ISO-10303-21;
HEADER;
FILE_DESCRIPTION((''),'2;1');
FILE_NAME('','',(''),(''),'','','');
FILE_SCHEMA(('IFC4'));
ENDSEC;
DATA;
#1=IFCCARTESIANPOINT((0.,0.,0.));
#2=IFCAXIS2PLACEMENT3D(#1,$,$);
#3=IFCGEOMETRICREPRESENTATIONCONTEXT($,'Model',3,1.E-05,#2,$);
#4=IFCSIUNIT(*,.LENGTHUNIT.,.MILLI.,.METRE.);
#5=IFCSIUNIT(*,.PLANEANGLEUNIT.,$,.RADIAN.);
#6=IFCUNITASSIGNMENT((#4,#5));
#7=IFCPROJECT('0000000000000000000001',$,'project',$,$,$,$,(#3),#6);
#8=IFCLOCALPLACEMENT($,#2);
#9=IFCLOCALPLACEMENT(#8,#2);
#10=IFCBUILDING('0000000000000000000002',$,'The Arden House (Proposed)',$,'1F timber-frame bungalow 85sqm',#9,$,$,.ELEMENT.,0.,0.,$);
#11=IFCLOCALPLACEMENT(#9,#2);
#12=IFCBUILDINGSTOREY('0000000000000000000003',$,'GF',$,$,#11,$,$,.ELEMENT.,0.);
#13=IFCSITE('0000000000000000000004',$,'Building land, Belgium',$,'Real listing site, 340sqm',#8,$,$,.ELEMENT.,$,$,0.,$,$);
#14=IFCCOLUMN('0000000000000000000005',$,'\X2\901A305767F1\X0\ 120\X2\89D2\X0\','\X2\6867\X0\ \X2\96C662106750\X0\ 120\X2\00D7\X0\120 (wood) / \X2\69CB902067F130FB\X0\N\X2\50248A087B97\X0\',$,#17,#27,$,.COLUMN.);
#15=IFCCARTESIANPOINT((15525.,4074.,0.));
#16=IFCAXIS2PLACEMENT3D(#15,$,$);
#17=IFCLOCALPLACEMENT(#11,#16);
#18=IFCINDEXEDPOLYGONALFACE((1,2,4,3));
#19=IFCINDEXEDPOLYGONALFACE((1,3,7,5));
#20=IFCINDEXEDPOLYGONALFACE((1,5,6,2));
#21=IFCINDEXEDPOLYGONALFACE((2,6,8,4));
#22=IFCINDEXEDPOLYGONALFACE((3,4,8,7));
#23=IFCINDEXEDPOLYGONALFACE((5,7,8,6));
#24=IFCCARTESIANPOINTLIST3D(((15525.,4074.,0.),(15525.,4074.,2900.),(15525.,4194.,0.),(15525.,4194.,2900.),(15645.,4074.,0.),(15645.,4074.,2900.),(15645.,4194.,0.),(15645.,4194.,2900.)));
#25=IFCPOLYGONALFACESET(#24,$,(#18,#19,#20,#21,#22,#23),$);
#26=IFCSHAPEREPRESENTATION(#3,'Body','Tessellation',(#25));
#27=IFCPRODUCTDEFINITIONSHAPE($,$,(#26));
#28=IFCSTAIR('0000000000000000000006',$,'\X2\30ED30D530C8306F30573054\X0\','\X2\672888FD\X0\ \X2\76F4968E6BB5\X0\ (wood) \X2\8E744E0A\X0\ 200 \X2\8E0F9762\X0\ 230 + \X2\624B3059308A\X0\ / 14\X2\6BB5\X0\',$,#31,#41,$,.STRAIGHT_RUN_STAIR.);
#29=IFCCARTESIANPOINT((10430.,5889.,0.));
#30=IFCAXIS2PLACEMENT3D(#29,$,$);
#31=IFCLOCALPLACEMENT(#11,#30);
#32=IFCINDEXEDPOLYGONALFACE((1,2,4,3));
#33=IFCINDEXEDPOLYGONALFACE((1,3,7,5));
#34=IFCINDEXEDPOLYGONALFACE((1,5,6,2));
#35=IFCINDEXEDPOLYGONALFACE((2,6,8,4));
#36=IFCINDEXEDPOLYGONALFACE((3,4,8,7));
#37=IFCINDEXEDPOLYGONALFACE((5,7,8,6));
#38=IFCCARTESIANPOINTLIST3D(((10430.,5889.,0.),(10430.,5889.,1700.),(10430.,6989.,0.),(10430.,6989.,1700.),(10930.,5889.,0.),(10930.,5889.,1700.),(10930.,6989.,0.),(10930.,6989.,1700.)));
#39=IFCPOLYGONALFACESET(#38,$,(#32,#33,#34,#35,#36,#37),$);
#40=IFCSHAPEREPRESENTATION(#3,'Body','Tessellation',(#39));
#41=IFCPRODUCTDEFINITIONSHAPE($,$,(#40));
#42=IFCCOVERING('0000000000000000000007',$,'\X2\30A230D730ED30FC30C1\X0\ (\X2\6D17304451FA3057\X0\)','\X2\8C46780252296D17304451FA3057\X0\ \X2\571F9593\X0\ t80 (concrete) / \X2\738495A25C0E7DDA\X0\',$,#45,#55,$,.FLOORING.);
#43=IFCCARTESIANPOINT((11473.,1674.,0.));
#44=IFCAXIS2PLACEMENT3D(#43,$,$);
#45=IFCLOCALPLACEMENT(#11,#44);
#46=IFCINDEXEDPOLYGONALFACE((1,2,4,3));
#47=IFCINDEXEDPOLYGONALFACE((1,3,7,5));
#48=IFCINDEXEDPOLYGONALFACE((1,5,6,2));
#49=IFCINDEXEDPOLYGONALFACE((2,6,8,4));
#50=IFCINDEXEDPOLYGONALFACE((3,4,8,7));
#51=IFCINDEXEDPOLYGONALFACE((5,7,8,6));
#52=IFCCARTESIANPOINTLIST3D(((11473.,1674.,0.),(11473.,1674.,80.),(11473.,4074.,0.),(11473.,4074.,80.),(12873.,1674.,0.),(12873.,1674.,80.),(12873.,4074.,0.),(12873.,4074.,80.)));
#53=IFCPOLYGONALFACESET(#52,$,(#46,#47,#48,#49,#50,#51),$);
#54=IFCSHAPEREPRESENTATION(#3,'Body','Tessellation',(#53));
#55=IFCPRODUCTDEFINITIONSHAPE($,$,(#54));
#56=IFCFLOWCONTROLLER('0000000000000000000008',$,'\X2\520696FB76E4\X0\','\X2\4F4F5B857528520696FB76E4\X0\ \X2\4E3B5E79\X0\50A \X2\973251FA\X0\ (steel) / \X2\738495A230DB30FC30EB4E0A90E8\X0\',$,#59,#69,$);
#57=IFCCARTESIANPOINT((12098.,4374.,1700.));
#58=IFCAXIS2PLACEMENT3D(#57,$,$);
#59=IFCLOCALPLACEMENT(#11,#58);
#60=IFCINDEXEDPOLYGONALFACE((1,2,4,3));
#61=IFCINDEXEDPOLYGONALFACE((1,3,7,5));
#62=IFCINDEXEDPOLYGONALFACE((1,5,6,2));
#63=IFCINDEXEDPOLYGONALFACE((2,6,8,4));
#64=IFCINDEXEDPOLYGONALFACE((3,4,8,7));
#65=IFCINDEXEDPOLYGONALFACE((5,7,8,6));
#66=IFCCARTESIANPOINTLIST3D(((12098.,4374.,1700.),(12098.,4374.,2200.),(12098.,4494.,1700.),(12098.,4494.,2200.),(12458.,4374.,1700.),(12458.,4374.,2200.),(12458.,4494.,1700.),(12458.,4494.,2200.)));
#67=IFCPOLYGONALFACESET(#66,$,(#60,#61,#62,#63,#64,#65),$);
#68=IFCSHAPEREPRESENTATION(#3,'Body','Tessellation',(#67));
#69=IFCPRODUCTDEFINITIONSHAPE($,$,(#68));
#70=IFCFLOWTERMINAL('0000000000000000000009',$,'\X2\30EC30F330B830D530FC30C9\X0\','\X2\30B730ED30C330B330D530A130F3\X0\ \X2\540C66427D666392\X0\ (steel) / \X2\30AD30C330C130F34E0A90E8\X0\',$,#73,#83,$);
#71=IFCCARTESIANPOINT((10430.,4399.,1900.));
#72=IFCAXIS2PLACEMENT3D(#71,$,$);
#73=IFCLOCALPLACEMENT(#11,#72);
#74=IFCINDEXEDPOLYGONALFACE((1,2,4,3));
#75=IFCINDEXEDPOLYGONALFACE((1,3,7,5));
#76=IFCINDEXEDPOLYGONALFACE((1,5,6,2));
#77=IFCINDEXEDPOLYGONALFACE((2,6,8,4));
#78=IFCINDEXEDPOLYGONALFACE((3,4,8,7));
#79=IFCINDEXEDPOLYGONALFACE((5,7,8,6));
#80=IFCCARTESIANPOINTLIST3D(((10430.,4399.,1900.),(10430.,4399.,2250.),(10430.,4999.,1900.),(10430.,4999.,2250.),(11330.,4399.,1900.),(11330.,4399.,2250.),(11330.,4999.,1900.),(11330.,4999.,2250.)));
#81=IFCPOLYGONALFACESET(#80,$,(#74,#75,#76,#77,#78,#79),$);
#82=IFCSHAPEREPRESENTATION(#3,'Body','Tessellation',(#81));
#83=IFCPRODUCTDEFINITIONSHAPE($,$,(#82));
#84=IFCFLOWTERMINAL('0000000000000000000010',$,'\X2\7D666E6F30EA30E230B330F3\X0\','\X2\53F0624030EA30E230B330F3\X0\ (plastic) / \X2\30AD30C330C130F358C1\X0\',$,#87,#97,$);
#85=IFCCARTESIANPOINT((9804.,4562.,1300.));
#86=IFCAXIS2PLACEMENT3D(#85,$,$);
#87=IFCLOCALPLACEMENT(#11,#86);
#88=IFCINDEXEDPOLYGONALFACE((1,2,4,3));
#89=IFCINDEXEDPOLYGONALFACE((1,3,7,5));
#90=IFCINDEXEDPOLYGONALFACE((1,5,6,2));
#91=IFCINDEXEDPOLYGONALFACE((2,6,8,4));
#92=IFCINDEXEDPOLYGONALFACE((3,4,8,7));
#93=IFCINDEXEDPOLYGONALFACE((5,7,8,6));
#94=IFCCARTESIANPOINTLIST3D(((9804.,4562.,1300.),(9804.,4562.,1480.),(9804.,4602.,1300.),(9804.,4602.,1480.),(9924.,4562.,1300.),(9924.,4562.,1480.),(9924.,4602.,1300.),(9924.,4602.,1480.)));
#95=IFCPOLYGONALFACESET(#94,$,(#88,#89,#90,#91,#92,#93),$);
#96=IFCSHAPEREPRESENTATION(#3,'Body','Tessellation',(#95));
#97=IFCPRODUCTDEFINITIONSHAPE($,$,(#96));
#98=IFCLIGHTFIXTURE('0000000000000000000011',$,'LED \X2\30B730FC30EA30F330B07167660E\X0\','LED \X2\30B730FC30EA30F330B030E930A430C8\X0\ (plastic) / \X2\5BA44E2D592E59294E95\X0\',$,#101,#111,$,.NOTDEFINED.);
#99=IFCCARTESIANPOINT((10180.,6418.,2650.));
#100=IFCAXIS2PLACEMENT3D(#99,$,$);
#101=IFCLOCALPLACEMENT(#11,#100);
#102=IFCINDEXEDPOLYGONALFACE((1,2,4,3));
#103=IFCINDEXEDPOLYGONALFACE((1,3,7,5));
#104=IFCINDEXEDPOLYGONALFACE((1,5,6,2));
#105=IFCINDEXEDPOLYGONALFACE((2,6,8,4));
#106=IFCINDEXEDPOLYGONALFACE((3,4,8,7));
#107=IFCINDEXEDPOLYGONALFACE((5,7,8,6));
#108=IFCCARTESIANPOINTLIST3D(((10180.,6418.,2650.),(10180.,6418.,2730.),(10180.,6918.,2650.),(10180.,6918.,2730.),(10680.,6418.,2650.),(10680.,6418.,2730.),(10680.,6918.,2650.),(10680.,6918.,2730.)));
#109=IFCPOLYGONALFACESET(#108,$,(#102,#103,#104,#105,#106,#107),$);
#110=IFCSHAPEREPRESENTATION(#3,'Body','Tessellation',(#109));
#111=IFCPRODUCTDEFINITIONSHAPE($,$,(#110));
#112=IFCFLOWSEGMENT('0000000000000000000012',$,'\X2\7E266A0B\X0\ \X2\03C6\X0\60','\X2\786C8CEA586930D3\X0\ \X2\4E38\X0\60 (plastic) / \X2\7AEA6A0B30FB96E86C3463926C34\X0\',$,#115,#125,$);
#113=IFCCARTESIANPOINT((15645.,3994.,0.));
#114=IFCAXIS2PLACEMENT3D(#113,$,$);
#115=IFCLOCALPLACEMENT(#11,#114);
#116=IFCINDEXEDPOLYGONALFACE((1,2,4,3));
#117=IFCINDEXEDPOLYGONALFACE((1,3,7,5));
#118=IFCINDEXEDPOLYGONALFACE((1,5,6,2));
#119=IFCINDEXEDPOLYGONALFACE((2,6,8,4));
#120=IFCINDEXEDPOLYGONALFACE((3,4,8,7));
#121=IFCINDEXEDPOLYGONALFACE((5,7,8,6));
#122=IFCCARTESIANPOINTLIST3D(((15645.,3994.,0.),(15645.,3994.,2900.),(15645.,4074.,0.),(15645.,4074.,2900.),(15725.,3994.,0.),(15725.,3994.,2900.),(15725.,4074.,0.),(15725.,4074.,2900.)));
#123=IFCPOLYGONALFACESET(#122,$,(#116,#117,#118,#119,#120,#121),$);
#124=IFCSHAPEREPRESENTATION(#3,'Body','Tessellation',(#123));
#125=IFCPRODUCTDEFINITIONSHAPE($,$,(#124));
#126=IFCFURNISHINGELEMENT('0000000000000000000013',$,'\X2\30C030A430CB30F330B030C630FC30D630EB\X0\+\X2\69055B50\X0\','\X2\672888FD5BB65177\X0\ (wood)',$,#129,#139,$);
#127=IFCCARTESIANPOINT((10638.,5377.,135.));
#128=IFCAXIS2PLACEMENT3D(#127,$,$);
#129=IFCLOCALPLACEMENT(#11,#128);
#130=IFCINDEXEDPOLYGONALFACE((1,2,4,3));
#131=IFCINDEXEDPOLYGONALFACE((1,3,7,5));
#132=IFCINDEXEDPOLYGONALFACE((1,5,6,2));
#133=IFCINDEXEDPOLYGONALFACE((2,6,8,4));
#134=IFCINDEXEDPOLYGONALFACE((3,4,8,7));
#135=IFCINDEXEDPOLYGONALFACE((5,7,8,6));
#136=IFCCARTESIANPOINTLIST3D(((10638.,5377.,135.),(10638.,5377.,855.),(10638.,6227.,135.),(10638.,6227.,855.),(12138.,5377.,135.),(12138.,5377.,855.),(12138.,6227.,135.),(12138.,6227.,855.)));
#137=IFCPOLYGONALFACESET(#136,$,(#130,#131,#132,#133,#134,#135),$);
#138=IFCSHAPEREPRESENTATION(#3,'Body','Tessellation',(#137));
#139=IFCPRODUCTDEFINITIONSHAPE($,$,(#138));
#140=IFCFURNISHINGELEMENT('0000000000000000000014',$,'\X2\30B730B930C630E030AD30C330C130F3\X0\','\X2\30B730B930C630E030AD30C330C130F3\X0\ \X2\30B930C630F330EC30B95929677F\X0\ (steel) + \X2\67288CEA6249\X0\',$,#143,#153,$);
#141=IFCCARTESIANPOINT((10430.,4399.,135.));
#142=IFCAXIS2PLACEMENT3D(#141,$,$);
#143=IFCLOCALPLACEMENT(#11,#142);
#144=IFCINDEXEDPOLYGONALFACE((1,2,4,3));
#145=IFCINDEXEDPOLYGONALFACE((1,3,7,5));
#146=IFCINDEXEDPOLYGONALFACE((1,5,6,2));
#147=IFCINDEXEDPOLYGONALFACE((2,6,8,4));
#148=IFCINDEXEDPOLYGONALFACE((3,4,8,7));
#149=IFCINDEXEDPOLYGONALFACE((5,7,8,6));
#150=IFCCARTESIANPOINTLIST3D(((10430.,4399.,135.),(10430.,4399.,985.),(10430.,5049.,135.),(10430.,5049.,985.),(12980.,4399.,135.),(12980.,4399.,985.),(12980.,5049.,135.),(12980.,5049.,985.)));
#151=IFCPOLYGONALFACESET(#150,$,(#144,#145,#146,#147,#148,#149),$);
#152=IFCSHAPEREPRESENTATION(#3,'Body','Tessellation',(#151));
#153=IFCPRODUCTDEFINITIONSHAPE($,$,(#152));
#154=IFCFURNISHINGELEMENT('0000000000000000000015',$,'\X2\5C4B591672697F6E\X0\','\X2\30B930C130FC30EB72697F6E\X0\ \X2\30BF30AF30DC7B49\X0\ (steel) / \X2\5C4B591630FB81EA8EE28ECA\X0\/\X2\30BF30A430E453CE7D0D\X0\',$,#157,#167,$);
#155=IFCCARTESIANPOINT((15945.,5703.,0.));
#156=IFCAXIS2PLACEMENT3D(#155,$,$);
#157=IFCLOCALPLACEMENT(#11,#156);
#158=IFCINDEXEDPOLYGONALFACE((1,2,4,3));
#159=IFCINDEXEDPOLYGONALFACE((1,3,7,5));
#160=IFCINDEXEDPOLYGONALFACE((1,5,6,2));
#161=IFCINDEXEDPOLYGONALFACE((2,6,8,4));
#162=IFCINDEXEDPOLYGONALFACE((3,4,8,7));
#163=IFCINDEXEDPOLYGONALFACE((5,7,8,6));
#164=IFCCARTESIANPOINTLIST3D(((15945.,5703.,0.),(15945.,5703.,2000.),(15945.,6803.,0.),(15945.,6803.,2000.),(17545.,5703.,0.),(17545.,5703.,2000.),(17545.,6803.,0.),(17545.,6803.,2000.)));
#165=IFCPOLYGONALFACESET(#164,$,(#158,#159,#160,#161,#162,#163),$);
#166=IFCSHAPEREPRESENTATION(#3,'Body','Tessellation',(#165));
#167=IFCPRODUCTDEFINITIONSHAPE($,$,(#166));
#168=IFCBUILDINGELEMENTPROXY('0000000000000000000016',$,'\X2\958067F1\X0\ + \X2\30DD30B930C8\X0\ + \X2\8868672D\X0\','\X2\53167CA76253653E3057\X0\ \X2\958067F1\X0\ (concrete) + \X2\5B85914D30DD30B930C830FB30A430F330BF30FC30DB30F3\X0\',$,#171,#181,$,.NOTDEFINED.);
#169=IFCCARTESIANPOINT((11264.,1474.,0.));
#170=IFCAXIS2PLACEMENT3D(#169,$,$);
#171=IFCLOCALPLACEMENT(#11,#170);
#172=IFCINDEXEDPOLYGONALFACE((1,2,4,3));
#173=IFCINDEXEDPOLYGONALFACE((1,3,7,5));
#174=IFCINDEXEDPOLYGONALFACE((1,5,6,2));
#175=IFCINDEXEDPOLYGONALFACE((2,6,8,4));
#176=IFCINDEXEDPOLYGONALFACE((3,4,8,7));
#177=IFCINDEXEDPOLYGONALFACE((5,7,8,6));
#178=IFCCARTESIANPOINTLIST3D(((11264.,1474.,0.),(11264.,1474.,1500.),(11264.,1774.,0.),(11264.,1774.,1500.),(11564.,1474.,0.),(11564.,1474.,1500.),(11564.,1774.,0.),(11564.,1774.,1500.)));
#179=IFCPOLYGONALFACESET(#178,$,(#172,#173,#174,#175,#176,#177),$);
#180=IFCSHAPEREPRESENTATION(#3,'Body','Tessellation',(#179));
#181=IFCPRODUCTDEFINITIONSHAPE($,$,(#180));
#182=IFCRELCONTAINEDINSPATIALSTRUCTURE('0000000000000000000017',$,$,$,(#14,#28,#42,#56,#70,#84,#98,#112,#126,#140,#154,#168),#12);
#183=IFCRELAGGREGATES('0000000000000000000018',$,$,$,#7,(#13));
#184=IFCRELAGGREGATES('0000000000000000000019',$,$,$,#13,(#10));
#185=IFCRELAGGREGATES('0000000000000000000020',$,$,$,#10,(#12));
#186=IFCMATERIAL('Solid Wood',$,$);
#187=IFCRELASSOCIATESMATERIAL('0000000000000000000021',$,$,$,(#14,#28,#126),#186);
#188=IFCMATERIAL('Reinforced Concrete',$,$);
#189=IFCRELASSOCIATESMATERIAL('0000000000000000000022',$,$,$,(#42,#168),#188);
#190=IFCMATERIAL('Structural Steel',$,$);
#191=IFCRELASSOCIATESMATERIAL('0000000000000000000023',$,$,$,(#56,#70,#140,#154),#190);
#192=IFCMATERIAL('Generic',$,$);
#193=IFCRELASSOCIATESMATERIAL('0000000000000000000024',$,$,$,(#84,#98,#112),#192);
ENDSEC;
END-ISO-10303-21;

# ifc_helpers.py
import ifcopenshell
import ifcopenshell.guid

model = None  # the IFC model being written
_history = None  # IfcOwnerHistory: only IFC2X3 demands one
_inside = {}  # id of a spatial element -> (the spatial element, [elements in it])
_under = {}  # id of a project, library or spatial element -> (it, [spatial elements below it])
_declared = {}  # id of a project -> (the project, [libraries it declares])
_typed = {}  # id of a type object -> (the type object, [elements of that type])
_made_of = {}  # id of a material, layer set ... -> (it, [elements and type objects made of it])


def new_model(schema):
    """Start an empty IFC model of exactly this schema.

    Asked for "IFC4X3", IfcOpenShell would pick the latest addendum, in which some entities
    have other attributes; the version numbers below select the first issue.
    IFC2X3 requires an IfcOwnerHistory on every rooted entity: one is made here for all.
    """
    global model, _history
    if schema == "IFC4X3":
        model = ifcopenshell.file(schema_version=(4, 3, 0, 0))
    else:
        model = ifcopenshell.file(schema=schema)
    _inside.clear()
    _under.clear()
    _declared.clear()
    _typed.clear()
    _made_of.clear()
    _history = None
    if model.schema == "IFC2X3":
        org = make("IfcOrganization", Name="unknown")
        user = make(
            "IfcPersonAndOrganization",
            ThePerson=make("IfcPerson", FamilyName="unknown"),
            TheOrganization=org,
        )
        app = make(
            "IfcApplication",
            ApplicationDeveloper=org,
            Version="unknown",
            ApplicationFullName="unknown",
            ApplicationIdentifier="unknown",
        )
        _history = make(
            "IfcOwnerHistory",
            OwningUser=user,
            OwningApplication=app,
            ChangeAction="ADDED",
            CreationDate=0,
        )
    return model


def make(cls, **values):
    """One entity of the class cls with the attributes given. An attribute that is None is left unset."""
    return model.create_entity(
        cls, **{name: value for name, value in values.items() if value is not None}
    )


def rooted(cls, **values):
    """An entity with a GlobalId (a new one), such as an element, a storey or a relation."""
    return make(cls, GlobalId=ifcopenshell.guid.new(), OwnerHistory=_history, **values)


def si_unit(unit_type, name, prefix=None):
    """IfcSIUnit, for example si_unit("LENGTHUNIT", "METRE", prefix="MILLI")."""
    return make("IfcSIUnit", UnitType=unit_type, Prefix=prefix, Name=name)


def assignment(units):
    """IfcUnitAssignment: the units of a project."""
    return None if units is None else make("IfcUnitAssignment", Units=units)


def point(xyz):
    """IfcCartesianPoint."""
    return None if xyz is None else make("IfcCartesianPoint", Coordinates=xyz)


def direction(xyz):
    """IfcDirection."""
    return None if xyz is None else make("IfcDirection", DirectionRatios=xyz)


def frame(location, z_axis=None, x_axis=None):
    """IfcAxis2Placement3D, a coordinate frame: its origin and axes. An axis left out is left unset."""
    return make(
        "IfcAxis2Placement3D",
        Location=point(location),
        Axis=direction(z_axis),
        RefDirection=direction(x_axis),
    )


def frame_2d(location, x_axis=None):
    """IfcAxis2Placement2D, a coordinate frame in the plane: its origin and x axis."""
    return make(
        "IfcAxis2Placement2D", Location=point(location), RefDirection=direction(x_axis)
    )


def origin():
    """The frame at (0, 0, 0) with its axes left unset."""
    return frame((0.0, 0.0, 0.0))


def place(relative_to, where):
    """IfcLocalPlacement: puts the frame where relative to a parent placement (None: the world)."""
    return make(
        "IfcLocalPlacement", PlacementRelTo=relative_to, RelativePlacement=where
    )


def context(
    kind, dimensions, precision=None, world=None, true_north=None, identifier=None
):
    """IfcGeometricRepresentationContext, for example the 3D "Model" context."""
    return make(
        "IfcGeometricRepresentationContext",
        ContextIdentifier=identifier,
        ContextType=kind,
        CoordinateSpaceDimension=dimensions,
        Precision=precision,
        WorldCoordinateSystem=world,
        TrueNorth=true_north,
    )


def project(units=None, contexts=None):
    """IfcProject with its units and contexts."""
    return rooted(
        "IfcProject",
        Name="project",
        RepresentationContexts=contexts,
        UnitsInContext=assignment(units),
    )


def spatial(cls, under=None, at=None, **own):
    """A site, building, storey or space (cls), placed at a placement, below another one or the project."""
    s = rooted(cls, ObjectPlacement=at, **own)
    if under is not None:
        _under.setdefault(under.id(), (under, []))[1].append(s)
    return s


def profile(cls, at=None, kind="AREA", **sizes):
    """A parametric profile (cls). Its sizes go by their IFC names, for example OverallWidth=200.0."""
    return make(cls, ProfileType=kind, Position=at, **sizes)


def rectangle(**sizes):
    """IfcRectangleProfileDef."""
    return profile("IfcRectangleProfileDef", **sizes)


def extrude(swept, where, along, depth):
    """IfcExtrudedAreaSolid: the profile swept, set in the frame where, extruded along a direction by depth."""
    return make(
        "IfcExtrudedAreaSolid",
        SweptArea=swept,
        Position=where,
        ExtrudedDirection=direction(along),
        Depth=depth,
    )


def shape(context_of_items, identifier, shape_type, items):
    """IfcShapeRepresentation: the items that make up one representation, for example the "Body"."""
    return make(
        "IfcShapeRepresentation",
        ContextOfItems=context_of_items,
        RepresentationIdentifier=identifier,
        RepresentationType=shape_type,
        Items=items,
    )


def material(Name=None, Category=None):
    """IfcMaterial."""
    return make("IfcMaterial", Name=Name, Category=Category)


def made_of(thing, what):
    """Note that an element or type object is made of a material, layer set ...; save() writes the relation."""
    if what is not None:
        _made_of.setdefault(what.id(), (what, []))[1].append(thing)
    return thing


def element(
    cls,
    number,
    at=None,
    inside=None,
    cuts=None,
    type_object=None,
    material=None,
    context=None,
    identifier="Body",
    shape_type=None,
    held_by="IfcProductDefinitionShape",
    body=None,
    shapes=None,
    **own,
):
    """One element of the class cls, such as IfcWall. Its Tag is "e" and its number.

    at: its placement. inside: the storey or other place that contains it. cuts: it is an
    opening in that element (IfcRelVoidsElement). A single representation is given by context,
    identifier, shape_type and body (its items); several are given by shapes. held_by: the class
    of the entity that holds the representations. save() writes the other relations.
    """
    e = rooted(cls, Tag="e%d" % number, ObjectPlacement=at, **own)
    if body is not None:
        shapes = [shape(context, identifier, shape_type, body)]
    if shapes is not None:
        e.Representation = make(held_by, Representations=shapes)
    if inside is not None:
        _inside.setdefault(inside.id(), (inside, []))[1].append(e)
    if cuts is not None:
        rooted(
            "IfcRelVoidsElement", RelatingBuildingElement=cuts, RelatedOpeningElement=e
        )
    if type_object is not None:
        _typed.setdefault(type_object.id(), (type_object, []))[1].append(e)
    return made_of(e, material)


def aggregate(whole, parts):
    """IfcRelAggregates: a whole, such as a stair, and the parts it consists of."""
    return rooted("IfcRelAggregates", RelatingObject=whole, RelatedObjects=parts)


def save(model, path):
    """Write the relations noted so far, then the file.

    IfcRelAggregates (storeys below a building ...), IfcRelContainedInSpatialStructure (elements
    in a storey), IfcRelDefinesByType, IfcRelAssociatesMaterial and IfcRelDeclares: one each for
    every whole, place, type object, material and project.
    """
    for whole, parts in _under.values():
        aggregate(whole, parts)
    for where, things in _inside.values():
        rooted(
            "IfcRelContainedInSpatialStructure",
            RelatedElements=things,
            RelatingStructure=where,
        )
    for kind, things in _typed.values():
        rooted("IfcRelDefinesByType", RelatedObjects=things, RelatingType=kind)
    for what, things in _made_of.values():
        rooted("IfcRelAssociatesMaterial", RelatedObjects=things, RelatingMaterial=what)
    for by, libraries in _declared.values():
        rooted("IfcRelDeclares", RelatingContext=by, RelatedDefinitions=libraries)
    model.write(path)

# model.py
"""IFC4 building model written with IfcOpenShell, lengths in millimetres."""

from ifc_helpers import new_model, si_unit, frame, frame_2d, origin, place, context, project, spatial, rectangle, extrude, material, element, save


model = new_model("IFC4")

# Units and contexts
model_context = context("Model", 3, precision=1e-05, world=origin())
ifc_project = project(units=[si_unit("LENGTHUNIT", "METRE", prefix="MILLI"), si_unit("PLANEANGLEUNIT", "RADIAN")], contexts=[model_context])

# Site, building, storey
site_placement = place(None, origin())
site = spatial("IfcSite", under=ifc_project, at=site_placement, Name="Building land, Belgium", ObjectType="Real listing site, 340sqm", CompositionType="ELEMENT", RefElevation=0.0)
building_placement = place(site_placement, origin())
building = spatial("IfcBuilding", under=site, at=building_placement, Name="The Arden House (Proposed)", ObjectType="1F timber-frame bungalow 85sqm", CompositionType="ELEMENT", ElevationOfRefHeight=0.0, ElevationOfTerrain=0.0)
storey_placement = place(building_placement, origin())
storey = spatial("IfcBuildingStorey", under=building, at=storey_placement, Name="GF", CompositionType="ELEMENT", Elevation=0.0)

# Column
ifc_material_1 = material(Name="Solid Wood")
column_1_placement = place(storey_placement, frame((15525.0, 4074.0, 0.0)))
element("IfcColumn", 1, at=column_1_placement, inside=storey, material=ifc_material_1, Name="通し柱 120角", Description="桧 集成材 120×120 (wood) / 構造柱・N値計算", PredefinedType="COLUMN", context=model_context, shape_type="SweptSolid", body=[
    extrude(rectangle(XDim=120.0, YDim=120.0, at=frame_2d((60.0, 60.0))), frame((15525.0, 4074.0, 0.0)), (0.0, 0.0, 1.0), 2900.0),
])

# Stair
stair_placement = place(storey_placement, frame((10430.0, 5889.0, 0.0)))
element("IfcStair", 2, at=stair_placement, inside=storey, material=ifc_material_1, Name="ロフトはしご", Description="木製 直階段 (wood) 蹴上 200 踏面 230 + 手すり / 14段", PredefinedType="STRAIGHT_RUN_STAIR", context=model_context, shape_type="SweptSolid", body=[
    extrude(rectangle(XDim=500.0, YDim=1100.0, at=frame_2d((250.0, 550.0))), frame((10430.0, 5889.0, 0.0)), (0.0, 0.0, 1.0), 1700.0),
])

# Covering
ifc_material_2 = material(Name="Reinforced Concrete")
covering_placement = place(storey_placement, frame((11473.0, 1674.0, 0.0)))
element("IfcCovering", 3, at=covering_placement, inside=storey, material=ifc_material_2, Name="アプローチ (洗い出し)", Description="豆砂利洗い出し 土間 t80 (concrete) / 玄関導線", PredefinedType="FLOORING", context=model_context, shape_type="SweptSolid", body=[
    extrude(rectangle(XDim=1400.0, YDim=2400.0, at=frame_2d((700.0, 1200.0))), frame((11473.0, 1674.0, 0.0)), (0.0, 0.0, 1.0), 80.0),
])

# Flow controller
ifc_material_3 = material(Name="Structural Steel")
flow_controller_placement = place(storey_placement, frame((12098.0, 4374.0, 1700.0)))
element("IfcFlowController", 4, at=flow_controller_placement, inside=storey, material=ifc_material_3, Name="分電盤", Description="住宅用分電盤 主幹50A 露出 (steel) / 玄関ホール上部", context=model_context, shape_type="SweptSolid", body=[
    extrude(rectangle(XDim=360.0, YDim=120.0, at=frame_2d((180.0, 60.0))), frame((12098.0, 4374.0, 1700.0)), (0.0, 0.0, 1.0), 500.0),
])

# Flow terminals
flow_terminal_1_placement = place(storey_placement, frame((10430.0, 4399.0, 1900.0)))
element("IfcFlowTerminal", 5, at=flow_terminal_1_placement, inside=storey, material=ifc_material_3, Name="レンジフード", Description="シロッコファン 同時給排 (steel) / キッチン上部", context=model_context, shape_type="SweptSolid", body=[
    extrude(rectangle(XDim=900.0, YDim=600.0, at=frame_2d((450.0, 300.0))), frame((10430.0, 4399.0, 1900.0)), (0.0, 0.0, 1.0), 350.0),
])
ifc_material_4 = material(Name="Generic")
flow_terminal_2_placement = place(storey_placement, frame((9804.0, 4562.0, 1300.0)))
element("IfcFlowTerminal", 6, at=flow_terminal_2_placement, inside=storey, material=ifc_material_4, Name="給湯リモコン", Description="台所リモコン (plastic) / キッチン壁", context=model_context, shape_type="SweptSolid", body=[
    extrude(rectangle(XDim=120.0, YDim=40.0, at=frame_2d((60.0, 20.0))), frame((9804.0, 4562.0, 1300.0)), (0.0, 0.0, 1.0), 180.0),
])

# Light fixture
light_fixture_placement = place(storey_placement, frame((10180.0, 6418.0, 2650.0)))
element("IfcLightFixture", 7, at=light_fixture_placement, inside=storey, material=ifc_material_4, Name="LED シーリング照明", Description="LED シーリングライト (plastic) / 室中央天井", PredefinedType="NOTDEFINED", context=model_context, shape_type="SweptSolid", body=[
    extrude(rectangle(XDim=500.0, YDim=500.0, at=frame_2d((250.0, 250.0))), frame((10180.0, 6418.0, 2650.0)), (0.0, 0.0, 1.0), 80.0),
])

# Flow segment
flow_segment_placement = place(storey_placement, frame((15645.0, 3994.0, 0.0)))
element("IfcFlowSegment", 8, at=flow_segment_placement, inside=storey, material=ifc_material_4, Name="縦樋 φ60", Description="硬質塩ビ 丸60 (plastic) / 竪樋・雨水排水", context=model_context, shape_type="SweptSolid", body=[
    extrude(rectangle(XDim=80.0, YDim=80.0, at=frame_2d((40.0, 40.0))), frame((15645.0, 3994.0, 0.0)), (0.0, 0.0, 1.0), 2900.0),
])

# Furnishing elements
furnishing_1_placement = place(storey_placement, frame((10638.0, 5377.0, 135.0)))
element("IfcFurnishingElement", 9, at=furnishing_1_placement, inside=storey, material=ifc_material_1, Name="ダイニングテーブル+椅子", Description="木製家具 (wood)", context=model_context, shape_type="SweptSolid", body=[
    extrude(rectangle(XDim=1500.0, YDim=850.0, at=frame_2d((750.0, 425.0))), frame((10638.0, 5377.0, 135.0)), (0.0, 0.0, 1.0), 720.0),
])
furnishing_2_placement = place(storey_placement, frame((10430.0, 4399.0, 135.0)))
element("IfcFurnishingElement", 10, at=furnishing_2_placement, inside=storey, material=ifc_material_3, Name="システムキッチン", Description="システムキッチン ステンレス天板 (steel) + 木質扉", context=model_context, shape_type="SweptSolid", body=[
    extrude(rectangle(XDim=2550.0, YDim=650.0, at=frame_2d((1275.0, 325.0))), frame((10430.0, 4399.0, 135.0)), (0.0, 0.0, 1.0), 850.0),
])
furnishing_3_placement = place(storey_placement, frame((15945.0, 5703.0, 0.0)))
element("IfcFurnishingElement", 11, at=furnishing_3_placement, inside=storey, material=ifc_material_3, Name="屋外物置", Description="スチール物置 タクボ等 (steel) / 屋外・自転車/タイヤ収納", context=model_context, shape_type="SweptSolid", body=[
    extrude(rectangle(XDim=1600.0, YDim=1100.0, at=frame_2d((800.0, 550.0))), frame((15945.0, 5703.0, 0.0)), (0.0, 0.0, 1.0), 2000.0),
])

# Building element proxy
proxy_placement = place(storey_placement, frame((11264.0, 1474.0, 0.0)))
element("IfcBuildingElementProxy", 12, at=proxy_placement, inside=storey, material=ifc_material_2, Name="門柱 + ポスト + 表札", Description="化粧打放し 門柱 (concrete) + 宅配ポスト・インターホン", PredefinedType="NOTDEFINED", context=model_context, shape_type="SweptSolid", body=[
    extrude(rectangle(XDim=300.0, YDim=300.0, at=frame_2d((150.0, 150.0))), frame((11264.0, 1474.0, 0.0)), (0.0, 0.0, 1.0), 1500.0),
])

save(model, "model.ifc")
